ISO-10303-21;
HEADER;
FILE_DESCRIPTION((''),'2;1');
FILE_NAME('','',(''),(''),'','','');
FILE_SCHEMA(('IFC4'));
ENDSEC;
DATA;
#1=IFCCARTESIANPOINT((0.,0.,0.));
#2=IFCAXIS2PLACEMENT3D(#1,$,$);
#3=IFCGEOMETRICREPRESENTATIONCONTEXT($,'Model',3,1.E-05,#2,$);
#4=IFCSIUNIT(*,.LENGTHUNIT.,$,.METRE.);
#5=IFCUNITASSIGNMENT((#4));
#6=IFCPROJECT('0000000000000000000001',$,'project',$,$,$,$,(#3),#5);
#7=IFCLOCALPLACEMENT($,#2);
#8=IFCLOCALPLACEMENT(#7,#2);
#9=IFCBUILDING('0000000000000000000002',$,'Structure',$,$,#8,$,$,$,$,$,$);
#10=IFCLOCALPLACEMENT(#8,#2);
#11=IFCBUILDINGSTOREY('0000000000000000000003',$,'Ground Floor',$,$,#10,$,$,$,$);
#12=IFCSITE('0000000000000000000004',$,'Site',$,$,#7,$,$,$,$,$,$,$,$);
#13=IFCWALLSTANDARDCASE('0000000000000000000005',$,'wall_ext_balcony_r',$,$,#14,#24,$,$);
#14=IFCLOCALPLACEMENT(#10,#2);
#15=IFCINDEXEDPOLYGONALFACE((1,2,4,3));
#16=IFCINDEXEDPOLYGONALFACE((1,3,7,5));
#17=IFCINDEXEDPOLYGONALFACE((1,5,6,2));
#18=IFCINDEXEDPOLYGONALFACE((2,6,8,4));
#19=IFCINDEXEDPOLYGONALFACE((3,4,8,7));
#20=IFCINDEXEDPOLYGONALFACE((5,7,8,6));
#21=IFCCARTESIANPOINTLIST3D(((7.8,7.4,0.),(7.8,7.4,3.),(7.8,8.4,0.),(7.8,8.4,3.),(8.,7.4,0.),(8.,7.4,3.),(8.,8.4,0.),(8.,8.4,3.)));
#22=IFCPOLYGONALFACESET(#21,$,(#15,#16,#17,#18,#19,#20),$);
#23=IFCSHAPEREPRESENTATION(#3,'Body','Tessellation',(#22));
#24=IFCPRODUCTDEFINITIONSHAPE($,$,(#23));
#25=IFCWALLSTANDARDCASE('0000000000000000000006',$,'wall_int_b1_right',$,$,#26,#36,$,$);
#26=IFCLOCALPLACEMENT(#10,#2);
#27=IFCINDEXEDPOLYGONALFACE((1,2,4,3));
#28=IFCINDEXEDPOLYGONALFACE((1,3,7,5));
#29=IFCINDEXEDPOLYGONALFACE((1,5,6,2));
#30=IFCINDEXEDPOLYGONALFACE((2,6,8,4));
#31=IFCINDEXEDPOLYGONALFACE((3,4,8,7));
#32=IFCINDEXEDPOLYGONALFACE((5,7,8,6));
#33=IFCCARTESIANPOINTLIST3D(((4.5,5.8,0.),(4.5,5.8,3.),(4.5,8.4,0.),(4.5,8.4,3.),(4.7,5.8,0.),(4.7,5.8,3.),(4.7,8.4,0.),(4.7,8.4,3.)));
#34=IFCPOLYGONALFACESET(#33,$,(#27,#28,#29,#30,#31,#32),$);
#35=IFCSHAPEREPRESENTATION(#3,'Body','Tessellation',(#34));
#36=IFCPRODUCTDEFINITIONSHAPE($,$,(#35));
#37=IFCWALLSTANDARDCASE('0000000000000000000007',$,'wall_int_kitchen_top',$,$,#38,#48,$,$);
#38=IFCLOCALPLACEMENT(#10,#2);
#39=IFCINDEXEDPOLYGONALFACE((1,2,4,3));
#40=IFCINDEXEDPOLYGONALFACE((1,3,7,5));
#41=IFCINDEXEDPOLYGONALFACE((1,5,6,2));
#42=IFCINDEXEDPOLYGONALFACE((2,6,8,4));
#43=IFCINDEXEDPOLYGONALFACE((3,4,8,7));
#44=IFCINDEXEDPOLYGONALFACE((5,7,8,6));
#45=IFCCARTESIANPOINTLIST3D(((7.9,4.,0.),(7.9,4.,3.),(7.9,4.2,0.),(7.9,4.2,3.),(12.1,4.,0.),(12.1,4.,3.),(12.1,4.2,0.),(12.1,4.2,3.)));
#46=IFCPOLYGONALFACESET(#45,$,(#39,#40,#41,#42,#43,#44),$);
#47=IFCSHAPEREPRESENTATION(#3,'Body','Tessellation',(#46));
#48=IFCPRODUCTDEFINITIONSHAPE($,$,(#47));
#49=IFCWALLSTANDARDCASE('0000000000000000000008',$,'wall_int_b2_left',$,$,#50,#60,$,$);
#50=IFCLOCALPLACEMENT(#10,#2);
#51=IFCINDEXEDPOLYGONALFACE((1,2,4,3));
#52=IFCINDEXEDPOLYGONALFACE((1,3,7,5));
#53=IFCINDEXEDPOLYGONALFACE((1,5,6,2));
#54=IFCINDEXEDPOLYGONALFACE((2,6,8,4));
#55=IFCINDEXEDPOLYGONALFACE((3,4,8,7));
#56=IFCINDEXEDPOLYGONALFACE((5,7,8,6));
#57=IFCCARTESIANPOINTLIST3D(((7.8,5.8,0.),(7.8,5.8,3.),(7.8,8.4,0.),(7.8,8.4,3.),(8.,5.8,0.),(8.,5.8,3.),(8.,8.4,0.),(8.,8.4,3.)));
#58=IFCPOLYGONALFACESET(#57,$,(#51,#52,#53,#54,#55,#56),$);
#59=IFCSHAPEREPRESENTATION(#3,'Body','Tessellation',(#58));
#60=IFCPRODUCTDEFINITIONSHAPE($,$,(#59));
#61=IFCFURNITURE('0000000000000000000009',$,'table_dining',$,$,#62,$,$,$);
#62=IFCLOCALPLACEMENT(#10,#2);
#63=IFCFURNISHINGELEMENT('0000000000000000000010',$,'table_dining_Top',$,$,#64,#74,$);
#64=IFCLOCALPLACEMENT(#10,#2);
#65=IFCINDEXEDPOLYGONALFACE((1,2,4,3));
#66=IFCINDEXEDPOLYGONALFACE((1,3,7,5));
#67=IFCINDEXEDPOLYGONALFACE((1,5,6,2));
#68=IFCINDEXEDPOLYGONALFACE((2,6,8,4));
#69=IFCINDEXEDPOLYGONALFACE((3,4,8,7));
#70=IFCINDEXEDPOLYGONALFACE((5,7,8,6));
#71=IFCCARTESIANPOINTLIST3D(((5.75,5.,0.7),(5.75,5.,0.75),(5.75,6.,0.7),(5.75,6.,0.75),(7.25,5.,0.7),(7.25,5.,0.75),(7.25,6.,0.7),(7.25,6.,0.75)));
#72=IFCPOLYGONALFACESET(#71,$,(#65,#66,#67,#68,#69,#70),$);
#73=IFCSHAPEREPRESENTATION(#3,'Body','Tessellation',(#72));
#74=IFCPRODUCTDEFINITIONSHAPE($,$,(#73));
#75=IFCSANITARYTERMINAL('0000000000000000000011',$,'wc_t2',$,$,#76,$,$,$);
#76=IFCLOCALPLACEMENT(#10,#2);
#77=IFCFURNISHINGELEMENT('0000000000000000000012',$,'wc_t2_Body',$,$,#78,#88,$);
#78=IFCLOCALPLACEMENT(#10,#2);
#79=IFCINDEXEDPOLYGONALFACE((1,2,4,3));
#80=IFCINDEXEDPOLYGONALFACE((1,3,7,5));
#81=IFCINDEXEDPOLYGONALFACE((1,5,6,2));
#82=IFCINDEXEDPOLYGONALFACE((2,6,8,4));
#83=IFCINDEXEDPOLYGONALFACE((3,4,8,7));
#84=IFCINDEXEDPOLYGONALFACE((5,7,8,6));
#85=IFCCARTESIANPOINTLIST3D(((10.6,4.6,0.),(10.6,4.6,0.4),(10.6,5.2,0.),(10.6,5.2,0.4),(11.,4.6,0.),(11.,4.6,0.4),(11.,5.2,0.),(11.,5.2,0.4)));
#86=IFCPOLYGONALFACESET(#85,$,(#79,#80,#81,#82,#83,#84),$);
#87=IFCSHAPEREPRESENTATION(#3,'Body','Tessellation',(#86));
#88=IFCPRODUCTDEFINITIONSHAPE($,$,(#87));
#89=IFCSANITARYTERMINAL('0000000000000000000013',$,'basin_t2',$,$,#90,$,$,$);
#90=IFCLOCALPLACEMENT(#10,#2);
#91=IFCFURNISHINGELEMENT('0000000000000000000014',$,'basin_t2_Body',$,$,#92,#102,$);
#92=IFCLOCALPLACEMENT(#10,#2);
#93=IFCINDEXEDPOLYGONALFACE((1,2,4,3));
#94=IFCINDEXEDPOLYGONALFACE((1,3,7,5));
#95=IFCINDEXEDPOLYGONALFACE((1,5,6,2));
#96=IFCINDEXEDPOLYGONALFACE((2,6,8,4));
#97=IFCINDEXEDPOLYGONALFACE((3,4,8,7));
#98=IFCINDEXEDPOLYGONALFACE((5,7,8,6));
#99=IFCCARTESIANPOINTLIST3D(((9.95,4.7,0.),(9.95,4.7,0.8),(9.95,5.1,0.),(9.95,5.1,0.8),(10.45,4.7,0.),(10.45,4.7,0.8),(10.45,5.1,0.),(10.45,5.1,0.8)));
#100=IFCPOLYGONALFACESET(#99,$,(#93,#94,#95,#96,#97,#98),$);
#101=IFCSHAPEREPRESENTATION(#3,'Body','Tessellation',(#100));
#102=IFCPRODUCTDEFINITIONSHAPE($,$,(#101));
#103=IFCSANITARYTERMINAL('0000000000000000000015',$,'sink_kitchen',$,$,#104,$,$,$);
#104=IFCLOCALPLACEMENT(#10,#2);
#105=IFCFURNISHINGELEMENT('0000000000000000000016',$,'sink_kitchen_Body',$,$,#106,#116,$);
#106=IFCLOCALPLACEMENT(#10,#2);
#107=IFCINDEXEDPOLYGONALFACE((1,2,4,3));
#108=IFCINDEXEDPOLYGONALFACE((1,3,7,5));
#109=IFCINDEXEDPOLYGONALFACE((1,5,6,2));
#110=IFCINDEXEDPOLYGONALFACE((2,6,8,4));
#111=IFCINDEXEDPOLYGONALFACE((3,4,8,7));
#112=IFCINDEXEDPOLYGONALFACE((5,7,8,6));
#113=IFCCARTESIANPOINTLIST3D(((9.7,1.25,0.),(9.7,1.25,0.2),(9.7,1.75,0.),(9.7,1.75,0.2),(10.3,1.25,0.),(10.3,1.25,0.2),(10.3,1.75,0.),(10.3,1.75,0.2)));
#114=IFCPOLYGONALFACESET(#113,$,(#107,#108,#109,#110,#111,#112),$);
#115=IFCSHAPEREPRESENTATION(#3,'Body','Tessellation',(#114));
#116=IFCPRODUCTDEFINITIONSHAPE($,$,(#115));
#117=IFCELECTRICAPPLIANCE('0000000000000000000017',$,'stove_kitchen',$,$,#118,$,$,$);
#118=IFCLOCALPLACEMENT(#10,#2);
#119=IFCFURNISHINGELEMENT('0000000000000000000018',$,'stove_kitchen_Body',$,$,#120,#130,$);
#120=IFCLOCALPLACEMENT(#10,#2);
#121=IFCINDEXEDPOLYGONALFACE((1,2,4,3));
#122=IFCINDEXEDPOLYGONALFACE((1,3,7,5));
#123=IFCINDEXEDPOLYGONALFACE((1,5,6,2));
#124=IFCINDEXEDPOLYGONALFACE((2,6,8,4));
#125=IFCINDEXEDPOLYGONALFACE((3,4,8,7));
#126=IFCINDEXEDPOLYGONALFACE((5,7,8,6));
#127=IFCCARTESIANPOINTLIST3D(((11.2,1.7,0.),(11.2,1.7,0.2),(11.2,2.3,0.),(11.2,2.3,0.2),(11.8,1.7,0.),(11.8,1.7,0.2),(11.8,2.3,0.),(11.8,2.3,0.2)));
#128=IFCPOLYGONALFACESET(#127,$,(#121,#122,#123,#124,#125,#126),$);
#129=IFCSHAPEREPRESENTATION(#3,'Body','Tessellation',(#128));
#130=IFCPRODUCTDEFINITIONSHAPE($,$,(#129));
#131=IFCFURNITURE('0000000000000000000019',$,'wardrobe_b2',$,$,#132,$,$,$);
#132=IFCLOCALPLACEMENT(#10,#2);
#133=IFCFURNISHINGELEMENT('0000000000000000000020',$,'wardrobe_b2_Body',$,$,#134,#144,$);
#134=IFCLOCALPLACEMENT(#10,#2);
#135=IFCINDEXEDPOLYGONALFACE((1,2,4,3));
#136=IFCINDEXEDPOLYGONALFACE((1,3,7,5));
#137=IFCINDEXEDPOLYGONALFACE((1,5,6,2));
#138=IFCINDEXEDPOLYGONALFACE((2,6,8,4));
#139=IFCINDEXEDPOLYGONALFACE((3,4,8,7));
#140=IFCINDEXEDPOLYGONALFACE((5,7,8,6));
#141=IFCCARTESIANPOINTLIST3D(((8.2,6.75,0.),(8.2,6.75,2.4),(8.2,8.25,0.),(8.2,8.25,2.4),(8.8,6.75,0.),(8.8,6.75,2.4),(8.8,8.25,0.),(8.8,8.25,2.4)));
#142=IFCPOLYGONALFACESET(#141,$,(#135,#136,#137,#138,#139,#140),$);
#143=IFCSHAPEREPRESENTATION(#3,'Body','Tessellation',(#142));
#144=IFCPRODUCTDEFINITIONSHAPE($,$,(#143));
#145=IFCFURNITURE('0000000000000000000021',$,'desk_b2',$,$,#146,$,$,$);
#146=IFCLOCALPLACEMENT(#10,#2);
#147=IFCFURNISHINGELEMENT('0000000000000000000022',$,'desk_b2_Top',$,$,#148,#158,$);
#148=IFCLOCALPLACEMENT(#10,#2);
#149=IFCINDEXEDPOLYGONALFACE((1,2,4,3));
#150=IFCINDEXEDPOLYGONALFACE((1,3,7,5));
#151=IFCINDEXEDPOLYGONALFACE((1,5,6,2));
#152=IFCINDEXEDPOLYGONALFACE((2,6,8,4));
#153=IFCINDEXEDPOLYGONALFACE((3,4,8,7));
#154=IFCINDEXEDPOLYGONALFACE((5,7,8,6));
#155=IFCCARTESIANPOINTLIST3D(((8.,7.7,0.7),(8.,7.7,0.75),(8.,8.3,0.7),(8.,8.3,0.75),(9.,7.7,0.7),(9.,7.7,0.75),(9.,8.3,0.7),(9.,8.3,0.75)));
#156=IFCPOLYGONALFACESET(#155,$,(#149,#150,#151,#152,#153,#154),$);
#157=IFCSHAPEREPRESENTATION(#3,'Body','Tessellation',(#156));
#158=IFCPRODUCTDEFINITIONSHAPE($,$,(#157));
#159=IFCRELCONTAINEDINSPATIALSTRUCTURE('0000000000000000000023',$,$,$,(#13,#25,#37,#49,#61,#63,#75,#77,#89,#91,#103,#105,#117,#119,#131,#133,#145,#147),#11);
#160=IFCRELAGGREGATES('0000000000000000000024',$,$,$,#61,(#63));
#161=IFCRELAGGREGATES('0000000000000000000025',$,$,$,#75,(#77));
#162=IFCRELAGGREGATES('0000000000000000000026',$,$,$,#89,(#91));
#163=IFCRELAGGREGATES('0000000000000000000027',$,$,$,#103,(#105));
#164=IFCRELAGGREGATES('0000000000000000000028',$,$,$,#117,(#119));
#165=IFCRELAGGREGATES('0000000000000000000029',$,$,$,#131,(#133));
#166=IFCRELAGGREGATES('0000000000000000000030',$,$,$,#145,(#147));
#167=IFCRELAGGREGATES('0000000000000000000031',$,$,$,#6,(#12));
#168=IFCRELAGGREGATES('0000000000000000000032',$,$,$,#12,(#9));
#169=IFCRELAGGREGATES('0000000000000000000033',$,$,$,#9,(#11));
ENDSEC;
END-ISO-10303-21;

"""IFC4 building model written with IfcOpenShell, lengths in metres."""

from ifc_helpers import new_model, si_unit, frame, origin, origin_2d, place, context, project, spatial, rectangle, extrude, element, aggregate, save


model = new_model("IFC4")

# Units and contexts
model_context = context("Model", 3, precision=1e-05, world=origin())
ifc_project = project(units=[si_unit("LENGTHUNIT", "METRE")], contexts=[model_context])

# Site, building, storey
site_placement = place(None, origin())
site = spatial("IfcSite", under=ifc_project, at=site_placement, Name="Site")
building_placement = place(site_placement, origin())
building = spatial("IfcBuilding", under=site, at=building_placement, Name="Structure")
storey_placement = place(building_placement, origin())
storey = spatial("IfcBuildingStorey", under=building, at=storey_placement, Name="Ground Floor")

# Walls
wall_1_placement = place(storey_placement, frame((7.9, 7.4, 0.0), x_axis=(0.0, 1.0, 0.0)))
element("IfcWallStandardCase", 1, at=wall_1_placement, inside=storey, Name="wall_ext_balcony_r", context=model_context, shape_type="SweptSolid", body=[
    extrude(rectangle(XDim=1.0, YDim=0.2, at=origin_2d()), frame((0.5, 0.0, 0.0)), (0.0, 0.0, 1.0), 3.0),
])
wall_2_placement = place(storey_placement, frame((4.6, 5.8, 0.0), x_axis=(0.0, 1.0, 0.0)))
element("IfcWallStandardCase", 2, at=wall_2_placement, inside=storey, Name="wall_int_b1_right", context=model_context, shape_type="SweptSolid", body=[
    extrude(rectangle(XDim=2.6, YDim=0.2, at=origin_2d()), frame((1.3, 0.0, 0.0)), (0.0, 0.0, 1.0), 3.0),
])
wall_3_placement = place(storey_placement, frame((7.9, 4.1, 0.0), x_axis=(1.0, 0.0, 0.0)))
element("IfcWallStandardCase", 3, at=wall_3_placement, inside=storey, Name="wall_int_kitchen_top", context=model_context, shape_type="SweptSolid", body=[
    extrude(rectangle(XDim=4.2, YDim=0.2, at=origin_2d()), frame((2.1, 0.0, 0.0)), (0.0, 0.0, 1.0), 3.0),
])
wall_4_placement = place(storey_placement, frame((7.9, 5.8, 0.0), x_axis=(0.0, 1.0, 0.0)))
element("IfcWallStandardCase", 4, at=wall_4_placement, inside=storey, Name="wall_int_b2_left", context=model_context, shape_type="SweptSolid", body=[
    extrude(rectangle(XDim=2.6, YDim=0.2, at=origin_2d()), frame((1.3, 0.0, 0.0)), (0.0, 0.0, 1.0), 3.0),
])

# Furniture, furnishing element
furniture_1_placement = place(storey_placement, frame((6.5, 5.5, 0.0)))
furniture_1 = element("IfcFurniture", 5, at=furniture_1_placement, inside=storey, Name="table_dining")
furnishing_1_placement = place(furniture_1_placement, origin())
furnishing_1 = element("IfcFurnishingElement", 6, at=furnishing_1_placement, inside=storey, Name="table_dining_Top", context=model_context, shape_type="SweptSolid", body=[
    extrude(rectangle(XDim=1.5, YDim=1.0, at=origin_2d()), frame((0.0, 0.0, 0.7)), (0.0, 0.0, 1.0), 0.05),
])
aggregate(furniture_1, [furnishing_1])

# Sanitary terminals, furnishing elements
sanitary_terminal_1_placement = place(storey_placement, frame((10.8, 4.9, 0.0)))
sanitary_terminal_1 = element("IfcSanitaryTerminal", 7, at=sanitary_terminal_1_placement, inside=storey, Name="wc_t2")
furnishing_2_placement = place(sanitary_terminal_1_placement, origin())
furnishing_2 = element("IfcFurnishingElement", 8, at=furnishing_2_placement, inside=storey, Name="wc_t2_Body", context=model_context, shape_type="SweptSolid", body=[
    extrude(rectangle(XDim=0.4, YDim=0.6, at=origin_2d()), origin(), (0.0, 0.0, 1.0), 0.4),
])
aggregate(sanitary_terminal_1, [furnishing_2])
sanitary_terminal_2_placement = place(storey_placement, frame((10.2, 4.9, 0.0)))
sanitary_terminal_2 = element("IfcSanitaryTerminal", 9, at=sanitary_terminal_2_placement, inside=storey, Name="basin_t2")
furnishing_3_placement = place(sanitary_terminal_2_placement, origin())
furnishing_3 = element("IfcFurnishingElement", 10, at=furnishing_3_placement, inside=storey, Name="basin_t2_Body", context=model_context, shape_type="SweptSolid", body=[
    extrude(rectangle(XDim=0.5, YDim=0.4, at=origin_2d()), origin(), (0.0, 0.0, 1.0), 0.8),
])
aggregate(sanitary_terminal_2, [furnishing_3])
sanitary_terminal_3_placement = place(storey_placement, frame((10.0, 1.5, 0.0)))
sanitary_terminal_3 = element("IfcSanitaryTerminal", 11, at=sanitary_terminal_3_placement, inside=storey, Name="sink_kitchen")
furnishing_4_placement = place(sanitary_terminal_3_placement, origin())
furnishing_4 = element("IfcFurnishingElement", 12, at=furnishing_4_placement, inside=storey, Name="sink_kitchen_Body", context=model_context, shape_type="SweptSolid", body=[
    extrude(rectangle(XDim=0.6, YDim=0.5, at=origin_2d()), origin(), (0.0, 0.0, 1.0), 0.2),
])
aggregate(sanitary_terminal_3, [furnishing_4])

# Electric appliance, furnishing element
electric_appliance_placement = place(storey_placement, frame((11.5, 2.0, 0.0)))
electric_appliance = element("IfcElectricAppliance", 13, at=electric_appliance_placement, inside=storey, Name="stove_kitchen")
furnishing_5_placement = place(electric_appliance_placement, origin())
furnishing_5 = element("IfcFurnishingElement", 14, at=furnishing_5_placement, inside=storey, Name="stove_kitchen_Body", context=model_context, shape_type="SweptSolid", body=[
    extrude(rectangle(XDim=0.6, YDim=0.6, at=origin_2d()), origin(), (0.0, 0.0, 1.0), 0.2),
])
aggregate(electric_appliance, [furnishing_5])

# Furniture, furnishing element
furniture_2_placement = place(storey_placement, frame((8.5, 7.5, 0.0)))
furniture_2 = element("IfcFurniture", 15, at=furniture_2_placement, inside=storey, Name="wardrobe_b2")
furnishing_6_placement = place(furniture_2_placement, origin())
furnishing_6 = element("IfcFurnishingElement", 16, at=furnishing_6_placement, inside=storey, Name="wardrobe_b2_Body", context=model_context, shape_type="SweptSolid", body=[
    extrude(rectangle(XDim=0.6, YDim=1.5, at=origin_2d()), origin(), (0.0, 0.0, 1.0), 2.4),
])
aggregate(furniture_2, [furnishing_6])

# Furniture, furnishing element
furniture_3_placement = place(storey_placement, frame((8.5, 8.0, 0.0)))
furniture_3 = element("IfcFurniture", 17, at=furniture_3_placement, inside=storey, Name="desk_b2")
furnishing_7_placement = place(furniture_3_placement, origin())
furnishing_7 = element("IfcFurnishingElement", 18, at=furnishing_7_placement, inside=storey, Name="desk_b2_Top", context=model_context, shape_type="SweptSolid", body=[
    extrude(rectangle(XDim=1.0, YDim=0.6, at=origin_2d()), frame((0.0, 0.0, 0.7)), (0.0, 0.0, 1.0), 0.05),
])
aggregate(furniture_3, [furnishing_7])

save(model, "model.ifc")
